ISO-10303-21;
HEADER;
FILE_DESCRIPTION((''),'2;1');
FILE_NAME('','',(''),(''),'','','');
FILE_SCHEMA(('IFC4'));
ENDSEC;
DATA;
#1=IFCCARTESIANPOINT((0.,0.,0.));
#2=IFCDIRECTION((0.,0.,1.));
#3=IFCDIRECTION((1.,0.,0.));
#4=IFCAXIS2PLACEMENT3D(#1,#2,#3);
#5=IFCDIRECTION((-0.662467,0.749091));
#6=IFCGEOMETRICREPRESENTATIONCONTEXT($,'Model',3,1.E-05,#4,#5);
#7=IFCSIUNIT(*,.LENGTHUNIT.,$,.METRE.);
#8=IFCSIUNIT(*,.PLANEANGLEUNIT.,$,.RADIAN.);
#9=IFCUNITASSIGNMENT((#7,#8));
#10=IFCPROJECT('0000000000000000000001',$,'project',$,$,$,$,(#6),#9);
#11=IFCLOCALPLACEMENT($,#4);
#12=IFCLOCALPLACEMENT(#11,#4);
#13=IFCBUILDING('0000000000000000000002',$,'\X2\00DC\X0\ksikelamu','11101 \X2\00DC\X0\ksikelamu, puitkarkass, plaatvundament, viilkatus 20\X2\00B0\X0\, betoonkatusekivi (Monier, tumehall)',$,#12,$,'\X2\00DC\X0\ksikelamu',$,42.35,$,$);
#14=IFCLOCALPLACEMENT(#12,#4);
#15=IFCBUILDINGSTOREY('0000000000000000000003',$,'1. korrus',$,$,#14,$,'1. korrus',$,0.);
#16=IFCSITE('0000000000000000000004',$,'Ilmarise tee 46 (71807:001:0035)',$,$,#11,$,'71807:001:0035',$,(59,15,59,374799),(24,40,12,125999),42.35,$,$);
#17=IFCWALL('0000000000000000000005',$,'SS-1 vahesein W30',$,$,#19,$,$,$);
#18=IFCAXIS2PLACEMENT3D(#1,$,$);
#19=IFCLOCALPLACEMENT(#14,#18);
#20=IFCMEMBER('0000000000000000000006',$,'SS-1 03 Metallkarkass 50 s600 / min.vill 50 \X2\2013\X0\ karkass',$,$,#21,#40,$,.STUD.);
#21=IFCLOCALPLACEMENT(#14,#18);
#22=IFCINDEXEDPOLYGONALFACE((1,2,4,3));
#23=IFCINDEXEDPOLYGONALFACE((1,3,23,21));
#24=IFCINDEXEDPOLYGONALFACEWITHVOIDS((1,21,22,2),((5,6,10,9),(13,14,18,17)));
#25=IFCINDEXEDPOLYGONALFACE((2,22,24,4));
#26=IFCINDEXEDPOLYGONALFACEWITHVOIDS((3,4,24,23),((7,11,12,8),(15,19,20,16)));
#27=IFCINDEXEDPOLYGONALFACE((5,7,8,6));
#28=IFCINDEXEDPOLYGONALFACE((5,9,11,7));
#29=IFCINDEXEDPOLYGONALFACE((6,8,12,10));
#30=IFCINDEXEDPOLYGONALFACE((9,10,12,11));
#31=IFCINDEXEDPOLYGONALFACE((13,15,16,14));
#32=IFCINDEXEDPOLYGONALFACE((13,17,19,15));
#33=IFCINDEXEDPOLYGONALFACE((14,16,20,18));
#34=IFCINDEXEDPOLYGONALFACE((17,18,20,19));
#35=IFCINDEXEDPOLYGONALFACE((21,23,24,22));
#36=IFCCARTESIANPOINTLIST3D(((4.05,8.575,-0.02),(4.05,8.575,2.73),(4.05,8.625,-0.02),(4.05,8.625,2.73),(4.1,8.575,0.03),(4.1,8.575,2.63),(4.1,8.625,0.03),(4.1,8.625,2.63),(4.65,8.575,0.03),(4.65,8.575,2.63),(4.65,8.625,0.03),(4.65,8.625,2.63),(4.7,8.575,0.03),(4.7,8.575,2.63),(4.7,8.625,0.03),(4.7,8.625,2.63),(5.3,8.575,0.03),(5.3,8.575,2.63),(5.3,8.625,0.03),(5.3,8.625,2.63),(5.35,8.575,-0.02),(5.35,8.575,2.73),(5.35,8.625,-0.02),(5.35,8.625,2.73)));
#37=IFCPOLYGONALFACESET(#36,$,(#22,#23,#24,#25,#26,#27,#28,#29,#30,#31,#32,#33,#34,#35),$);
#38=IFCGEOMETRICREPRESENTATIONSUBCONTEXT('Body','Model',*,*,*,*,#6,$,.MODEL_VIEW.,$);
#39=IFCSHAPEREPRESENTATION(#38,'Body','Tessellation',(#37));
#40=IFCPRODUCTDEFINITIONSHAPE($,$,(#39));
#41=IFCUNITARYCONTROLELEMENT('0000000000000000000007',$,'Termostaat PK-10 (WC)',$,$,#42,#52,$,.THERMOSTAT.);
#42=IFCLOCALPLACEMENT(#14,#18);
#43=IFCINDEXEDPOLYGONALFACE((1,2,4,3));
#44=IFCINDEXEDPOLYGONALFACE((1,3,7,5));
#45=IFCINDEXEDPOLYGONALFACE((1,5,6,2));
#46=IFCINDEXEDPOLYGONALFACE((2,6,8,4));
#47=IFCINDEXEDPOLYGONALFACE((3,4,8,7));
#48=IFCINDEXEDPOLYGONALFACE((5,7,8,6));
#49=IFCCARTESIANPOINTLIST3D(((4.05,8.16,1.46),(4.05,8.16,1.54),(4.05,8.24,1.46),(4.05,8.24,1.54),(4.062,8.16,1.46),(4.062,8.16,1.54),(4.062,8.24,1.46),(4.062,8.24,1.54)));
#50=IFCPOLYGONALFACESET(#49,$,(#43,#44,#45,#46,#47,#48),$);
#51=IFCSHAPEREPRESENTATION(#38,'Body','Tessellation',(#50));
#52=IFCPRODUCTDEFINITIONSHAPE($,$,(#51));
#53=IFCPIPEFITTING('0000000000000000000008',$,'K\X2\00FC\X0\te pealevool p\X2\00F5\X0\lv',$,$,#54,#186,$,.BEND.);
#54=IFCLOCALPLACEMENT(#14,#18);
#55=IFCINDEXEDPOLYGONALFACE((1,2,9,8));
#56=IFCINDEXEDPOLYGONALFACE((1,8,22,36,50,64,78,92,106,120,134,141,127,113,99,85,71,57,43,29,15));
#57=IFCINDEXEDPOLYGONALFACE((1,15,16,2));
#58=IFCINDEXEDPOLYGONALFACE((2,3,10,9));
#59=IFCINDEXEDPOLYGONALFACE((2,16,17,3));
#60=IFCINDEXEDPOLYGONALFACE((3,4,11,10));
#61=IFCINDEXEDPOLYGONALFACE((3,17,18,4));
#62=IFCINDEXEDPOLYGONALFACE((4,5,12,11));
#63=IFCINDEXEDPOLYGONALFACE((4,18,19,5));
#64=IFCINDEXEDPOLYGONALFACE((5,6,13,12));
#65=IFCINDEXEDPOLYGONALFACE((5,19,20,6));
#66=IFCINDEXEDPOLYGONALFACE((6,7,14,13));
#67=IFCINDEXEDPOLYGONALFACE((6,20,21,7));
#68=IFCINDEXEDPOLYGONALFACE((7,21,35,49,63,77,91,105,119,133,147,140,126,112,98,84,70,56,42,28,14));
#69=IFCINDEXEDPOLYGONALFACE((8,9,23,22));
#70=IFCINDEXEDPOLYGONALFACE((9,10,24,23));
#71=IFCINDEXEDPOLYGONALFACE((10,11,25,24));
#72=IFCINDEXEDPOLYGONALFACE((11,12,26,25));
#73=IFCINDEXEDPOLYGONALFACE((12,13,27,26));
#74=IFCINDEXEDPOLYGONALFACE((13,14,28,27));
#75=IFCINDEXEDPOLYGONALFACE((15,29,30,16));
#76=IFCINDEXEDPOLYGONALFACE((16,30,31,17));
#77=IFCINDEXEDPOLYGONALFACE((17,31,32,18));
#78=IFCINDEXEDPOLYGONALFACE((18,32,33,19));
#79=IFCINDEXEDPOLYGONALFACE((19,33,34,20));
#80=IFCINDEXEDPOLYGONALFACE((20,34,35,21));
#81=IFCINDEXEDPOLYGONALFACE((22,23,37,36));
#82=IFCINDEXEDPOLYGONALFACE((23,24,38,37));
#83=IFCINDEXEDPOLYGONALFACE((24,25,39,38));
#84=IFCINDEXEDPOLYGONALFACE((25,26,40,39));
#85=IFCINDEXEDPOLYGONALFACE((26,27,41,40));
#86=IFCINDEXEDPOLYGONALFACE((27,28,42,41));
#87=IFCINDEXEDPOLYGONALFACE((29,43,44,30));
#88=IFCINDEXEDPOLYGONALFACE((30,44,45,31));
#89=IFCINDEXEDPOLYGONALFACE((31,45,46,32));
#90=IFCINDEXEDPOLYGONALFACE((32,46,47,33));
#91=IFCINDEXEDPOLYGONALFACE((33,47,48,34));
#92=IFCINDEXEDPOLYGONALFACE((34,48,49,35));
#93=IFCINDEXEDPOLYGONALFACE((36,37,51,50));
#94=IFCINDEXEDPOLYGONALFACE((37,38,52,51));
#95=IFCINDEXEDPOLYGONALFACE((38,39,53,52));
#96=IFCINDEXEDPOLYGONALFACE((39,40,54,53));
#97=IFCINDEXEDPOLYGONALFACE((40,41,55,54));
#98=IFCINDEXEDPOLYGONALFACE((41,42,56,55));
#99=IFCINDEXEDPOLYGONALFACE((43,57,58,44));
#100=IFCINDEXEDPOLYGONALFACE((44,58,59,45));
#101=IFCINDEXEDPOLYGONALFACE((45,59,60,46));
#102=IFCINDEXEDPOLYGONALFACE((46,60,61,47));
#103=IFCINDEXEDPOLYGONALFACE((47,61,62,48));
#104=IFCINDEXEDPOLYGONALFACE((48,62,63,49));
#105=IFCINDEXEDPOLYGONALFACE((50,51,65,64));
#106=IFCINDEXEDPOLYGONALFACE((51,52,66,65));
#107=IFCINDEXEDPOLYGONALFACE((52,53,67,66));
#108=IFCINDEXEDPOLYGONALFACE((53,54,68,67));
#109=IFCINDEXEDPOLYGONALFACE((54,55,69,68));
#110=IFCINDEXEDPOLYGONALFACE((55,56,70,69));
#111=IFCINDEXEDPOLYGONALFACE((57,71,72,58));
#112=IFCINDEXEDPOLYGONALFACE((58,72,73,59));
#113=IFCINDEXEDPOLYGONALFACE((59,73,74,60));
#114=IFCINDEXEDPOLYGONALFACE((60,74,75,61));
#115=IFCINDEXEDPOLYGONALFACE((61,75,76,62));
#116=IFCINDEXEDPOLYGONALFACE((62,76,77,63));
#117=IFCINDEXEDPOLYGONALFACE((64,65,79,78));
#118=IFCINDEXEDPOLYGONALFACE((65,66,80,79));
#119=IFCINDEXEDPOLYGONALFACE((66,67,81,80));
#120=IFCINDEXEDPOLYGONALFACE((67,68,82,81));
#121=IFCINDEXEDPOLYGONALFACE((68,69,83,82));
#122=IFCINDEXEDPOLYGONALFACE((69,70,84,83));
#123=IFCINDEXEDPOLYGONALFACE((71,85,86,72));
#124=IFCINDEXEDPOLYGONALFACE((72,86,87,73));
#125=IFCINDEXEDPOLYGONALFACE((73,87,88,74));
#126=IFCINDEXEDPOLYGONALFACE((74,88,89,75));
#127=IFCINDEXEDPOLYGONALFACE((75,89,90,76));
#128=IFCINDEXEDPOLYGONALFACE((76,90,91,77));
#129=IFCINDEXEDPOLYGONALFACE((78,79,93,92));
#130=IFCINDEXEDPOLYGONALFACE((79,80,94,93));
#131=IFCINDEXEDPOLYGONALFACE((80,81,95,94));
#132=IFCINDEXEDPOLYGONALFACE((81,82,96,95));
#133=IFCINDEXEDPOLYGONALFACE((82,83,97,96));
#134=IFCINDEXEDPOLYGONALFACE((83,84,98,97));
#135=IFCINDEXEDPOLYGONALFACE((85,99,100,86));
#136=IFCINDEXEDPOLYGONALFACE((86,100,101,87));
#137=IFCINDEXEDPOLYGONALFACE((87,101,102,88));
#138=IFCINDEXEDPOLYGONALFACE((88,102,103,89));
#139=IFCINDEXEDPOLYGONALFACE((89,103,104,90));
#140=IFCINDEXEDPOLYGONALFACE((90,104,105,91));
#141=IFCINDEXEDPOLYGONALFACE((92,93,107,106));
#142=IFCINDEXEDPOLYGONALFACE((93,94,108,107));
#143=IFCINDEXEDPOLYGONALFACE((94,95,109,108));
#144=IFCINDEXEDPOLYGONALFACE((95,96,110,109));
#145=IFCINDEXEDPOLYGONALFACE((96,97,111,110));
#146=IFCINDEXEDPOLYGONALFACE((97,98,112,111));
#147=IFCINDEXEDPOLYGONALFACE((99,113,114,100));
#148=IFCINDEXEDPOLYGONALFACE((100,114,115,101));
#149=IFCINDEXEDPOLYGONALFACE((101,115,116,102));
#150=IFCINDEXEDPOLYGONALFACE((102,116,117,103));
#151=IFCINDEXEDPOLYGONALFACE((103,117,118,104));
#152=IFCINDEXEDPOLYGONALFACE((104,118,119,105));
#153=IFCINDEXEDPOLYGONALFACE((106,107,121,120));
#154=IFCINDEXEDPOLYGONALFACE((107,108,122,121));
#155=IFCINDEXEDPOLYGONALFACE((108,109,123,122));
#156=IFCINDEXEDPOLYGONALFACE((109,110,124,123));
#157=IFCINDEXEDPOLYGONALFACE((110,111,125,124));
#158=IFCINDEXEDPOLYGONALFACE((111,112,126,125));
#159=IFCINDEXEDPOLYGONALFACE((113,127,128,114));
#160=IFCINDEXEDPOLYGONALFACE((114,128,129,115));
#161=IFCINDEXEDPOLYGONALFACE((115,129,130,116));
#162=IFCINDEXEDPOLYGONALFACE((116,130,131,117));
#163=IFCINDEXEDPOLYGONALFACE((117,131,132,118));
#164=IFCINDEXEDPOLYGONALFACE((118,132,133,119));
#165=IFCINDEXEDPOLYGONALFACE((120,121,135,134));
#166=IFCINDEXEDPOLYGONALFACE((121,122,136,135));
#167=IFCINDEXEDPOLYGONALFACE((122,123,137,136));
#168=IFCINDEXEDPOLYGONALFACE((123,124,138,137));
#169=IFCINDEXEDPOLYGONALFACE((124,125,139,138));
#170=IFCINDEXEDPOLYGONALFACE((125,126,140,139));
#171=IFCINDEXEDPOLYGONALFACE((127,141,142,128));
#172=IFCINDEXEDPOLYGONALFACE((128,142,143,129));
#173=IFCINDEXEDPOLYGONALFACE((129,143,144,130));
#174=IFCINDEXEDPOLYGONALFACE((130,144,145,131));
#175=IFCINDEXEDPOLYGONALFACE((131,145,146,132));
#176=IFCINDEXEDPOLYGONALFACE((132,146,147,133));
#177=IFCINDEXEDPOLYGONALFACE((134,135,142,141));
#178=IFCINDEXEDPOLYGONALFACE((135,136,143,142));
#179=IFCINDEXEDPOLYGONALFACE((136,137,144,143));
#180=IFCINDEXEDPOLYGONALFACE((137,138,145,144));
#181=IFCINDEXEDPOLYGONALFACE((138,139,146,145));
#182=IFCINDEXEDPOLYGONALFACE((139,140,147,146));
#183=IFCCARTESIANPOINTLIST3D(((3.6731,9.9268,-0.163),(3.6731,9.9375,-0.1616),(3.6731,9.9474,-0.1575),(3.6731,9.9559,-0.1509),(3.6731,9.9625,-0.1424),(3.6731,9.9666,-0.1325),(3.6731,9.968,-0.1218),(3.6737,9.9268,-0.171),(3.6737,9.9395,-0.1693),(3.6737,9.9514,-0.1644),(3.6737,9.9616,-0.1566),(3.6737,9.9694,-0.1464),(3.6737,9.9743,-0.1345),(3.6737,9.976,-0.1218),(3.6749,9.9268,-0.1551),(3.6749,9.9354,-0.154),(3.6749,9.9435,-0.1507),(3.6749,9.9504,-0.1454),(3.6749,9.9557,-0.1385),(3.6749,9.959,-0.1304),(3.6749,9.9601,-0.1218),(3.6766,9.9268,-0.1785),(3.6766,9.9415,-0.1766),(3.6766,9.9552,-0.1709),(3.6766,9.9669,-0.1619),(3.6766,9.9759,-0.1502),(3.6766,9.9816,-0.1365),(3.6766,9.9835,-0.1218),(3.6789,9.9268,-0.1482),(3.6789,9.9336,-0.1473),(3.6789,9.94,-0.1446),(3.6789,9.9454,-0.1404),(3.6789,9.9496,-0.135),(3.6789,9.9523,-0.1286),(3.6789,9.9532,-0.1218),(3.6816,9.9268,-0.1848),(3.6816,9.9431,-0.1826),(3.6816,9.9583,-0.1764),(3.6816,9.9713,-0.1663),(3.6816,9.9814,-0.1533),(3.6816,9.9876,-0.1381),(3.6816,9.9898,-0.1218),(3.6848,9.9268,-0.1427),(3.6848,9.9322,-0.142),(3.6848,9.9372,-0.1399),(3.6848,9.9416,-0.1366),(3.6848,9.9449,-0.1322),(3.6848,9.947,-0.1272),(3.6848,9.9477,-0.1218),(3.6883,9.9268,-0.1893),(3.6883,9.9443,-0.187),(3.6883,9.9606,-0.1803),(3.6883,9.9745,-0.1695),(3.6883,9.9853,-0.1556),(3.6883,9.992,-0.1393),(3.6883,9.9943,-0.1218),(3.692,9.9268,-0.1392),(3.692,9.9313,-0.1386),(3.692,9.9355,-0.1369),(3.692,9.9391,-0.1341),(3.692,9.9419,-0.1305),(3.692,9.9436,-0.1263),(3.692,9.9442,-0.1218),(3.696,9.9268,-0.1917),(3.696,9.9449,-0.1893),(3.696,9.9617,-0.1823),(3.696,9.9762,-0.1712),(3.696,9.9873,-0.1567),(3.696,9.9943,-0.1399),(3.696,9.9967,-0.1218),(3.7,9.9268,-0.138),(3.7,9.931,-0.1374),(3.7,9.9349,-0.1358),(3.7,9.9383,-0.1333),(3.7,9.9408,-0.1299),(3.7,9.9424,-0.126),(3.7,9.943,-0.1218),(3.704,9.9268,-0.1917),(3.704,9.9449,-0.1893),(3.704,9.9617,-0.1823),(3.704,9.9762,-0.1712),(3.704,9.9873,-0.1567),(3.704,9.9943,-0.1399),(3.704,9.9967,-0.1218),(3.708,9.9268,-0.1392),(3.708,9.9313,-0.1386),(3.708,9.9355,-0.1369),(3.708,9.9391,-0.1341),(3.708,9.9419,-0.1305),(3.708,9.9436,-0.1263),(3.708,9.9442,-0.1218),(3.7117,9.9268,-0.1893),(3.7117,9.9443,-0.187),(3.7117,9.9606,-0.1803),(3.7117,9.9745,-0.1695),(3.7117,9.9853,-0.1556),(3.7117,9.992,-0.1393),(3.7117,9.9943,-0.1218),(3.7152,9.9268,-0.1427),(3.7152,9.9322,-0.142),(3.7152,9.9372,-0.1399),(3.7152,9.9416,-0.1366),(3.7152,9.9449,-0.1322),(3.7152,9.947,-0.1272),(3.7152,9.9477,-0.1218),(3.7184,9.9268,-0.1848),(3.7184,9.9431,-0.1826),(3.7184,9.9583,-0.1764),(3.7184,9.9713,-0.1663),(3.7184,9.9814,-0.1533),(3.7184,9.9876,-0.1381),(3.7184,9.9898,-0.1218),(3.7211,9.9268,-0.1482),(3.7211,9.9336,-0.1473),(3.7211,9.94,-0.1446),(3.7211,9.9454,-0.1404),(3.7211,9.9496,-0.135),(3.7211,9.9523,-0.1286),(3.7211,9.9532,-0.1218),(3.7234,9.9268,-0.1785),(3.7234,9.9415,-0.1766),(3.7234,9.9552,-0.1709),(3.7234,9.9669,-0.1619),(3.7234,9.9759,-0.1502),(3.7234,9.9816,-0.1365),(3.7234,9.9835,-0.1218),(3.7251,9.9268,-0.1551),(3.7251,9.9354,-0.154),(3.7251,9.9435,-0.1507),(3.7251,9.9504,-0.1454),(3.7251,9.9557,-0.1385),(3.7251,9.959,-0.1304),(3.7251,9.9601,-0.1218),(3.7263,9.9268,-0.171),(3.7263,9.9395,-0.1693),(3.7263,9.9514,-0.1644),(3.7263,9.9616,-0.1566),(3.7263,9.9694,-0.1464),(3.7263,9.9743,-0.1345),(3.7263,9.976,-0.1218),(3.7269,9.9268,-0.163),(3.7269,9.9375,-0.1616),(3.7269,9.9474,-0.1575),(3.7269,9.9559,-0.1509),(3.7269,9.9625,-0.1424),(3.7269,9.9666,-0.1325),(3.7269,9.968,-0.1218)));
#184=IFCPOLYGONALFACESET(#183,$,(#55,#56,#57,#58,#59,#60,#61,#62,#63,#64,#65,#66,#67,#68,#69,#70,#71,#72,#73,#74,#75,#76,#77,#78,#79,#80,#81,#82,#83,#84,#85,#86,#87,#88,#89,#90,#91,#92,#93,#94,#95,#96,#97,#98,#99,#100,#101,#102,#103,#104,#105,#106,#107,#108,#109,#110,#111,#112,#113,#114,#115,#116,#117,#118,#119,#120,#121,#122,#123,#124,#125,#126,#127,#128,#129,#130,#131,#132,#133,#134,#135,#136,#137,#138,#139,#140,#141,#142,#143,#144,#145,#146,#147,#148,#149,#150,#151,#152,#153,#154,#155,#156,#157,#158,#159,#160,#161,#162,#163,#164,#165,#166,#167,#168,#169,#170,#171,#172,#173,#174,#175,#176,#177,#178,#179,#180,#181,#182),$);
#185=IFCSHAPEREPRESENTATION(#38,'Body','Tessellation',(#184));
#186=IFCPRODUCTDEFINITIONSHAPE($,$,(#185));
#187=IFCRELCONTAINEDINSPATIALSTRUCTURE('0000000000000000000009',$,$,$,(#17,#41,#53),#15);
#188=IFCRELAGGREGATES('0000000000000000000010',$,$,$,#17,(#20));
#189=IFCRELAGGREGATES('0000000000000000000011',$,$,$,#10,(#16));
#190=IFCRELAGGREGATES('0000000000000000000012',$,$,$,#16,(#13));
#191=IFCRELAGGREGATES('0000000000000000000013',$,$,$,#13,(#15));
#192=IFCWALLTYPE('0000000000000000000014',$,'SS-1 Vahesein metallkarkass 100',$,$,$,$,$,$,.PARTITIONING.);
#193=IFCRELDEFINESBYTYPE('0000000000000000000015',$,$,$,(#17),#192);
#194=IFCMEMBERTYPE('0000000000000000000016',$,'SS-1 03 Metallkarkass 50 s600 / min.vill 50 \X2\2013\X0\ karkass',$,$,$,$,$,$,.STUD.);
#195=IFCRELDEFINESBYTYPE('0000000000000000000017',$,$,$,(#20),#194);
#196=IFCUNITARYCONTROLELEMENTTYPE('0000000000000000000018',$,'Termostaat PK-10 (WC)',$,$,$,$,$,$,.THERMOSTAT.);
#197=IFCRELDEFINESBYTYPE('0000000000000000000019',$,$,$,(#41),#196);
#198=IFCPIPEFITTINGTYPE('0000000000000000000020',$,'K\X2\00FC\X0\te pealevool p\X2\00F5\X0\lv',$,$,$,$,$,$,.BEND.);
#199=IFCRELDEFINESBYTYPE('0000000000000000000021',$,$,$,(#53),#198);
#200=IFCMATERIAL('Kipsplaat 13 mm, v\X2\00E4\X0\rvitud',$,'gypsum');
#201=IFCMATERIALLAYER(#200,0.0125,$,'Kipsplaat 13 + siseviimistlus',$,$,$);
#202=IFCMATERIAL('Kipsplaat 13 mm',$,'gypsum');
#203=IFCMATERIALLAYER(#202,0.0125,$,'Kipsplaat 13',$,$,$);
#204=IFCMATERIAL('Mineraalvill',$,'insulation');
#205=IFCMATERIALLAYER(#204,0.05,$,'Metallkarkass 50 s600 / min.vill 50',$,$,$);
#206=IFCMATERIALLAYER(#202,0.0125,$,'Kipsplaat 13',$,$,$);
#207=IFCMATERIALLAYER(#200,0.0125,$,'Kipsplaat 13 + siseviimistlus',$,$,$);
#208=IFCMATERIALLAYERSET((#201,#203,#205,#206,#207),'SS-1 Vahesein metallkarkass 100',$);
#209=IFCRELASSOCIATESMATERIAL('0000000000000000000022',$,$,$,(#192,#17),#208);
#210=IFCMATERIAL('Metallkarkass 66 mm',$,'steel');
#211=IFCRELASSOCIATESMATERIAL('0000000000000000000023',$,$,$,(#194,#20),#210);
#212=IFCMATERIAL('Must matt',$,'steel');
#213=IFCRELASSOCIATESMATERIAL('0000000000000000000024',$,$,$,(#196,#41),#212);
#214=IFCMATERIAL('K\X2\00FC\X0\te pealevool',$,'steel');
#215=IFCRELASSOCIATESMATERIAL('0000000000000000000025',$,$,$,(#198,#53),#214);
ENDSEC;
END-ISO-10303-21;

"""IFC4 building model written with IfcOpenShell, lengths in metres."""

from ifc_helpers import new_model, entity, si_unit, direction, frame, origin_with_axes, place, context, subcontext, project, spatial, indexed_curve, outline, extrude, material, layer, layer_set, layer_usage, type_object, element, aggregate, save


model = new_model("IFC4")

# Units and contexts
model_context = context("Model", 3, precision=1e-05, world=origin_with_axes(), true_north=direction((-0.662467, 0.749091)))
body_context = subcontext(model_context, "Body", "Model", "MODEL_VIEW")
ifc_project = project(units=[si_unit("LENGTHUNIT", "METRE"), si_unit("PLANEANGLEUNIT", "RADIAN")], contexts=[model_context])

# Site, building, storey
site_placement = place(None, origin_with_axes())
site = spatial("IfcSite", under=ifc_project, at=site_placement, Name="Ilmarise tee 46 (71807:001:0035)", LongName="71807:001:0035", RefLatitude=(59, 15, 59, 374799), RefLongitude=(24, 40, 12, 125999), RefElevation=42.35)
building_placement = place(site_placement, origin_with_axes())
building = spatial("IfcBuilding", under=site, at=building_placement, Name="Üksikelamu", Description="11101 Üksikelamu, puitkarkass, plaatvundament, viilkatus 20°, betoonkatusekivi (Monier, tumehall)", LongName="Üksikelamu", ElevationOfRefHeight=42.35)
storey_placement = place(building_placement, origin_with_axes())
storey = spatial("IfcBuildingStorey", under=building, at=storey_placement, Name="1. korrus", LongName="1. korrus", Elevation=0.0)

# Wall, member
ifc_material_1 = material(Name="Kipsplaat 13 mm, värvitud", Category="gypsum")
ifc_layer_1 = layer(ifc_material_1, 0.0125, Name="Kipsplaat 13 + siseviimistlus")
ifc_material_2 = material(Name="Kipsplaat 13 mm", Category="gypsum")
ifc_layer_2 = layer(ifc_material_2, 0.0125, Name="Kipsplaat 13")
ifc_material_3 = material(Name="Mineraalvill", Category="insulation")
ifc_layer_3 = layer(ifc_material_3, 0.05, Name="Metallkarkass 50 s600 / min.vill 50")
ifc_layer_4 = layer(ifc_material_2, 0.0125, Name="Kipsplaat 13")
ifc_layer_5 = layer(ifc_material_1, 0.0125, Name="Kipsplaat 13 + siseviimistlus")
ifc_layer_set = layer_set([ifc_layer_1, ifc_layer_2, ifc_layer_3, ifc_layer_4, ifc_layer_5], Name="SS-1 Vahesein metallkarkass 100")
ifc_layer_usage = layer_usage(ifc_layer_set, "AXIS2", "POSITIVE", 0.0)
wall_type = type_object("IfcWallType", Name="SS-1 Vahesein metallkarkass 100", PredefinedType="PARTITIONING", material=ifc_layer_set)
wall_placement = place(storey_placement, frame((4.05, 8.55, 0.0), z_axis=(0.0, 0.0, 1.0), x_axis=(1.0, 0.0, 0.0)))
wall = element("IfcWall", 1, at=wall_placement, inside=storey, type_object=wall_type, material=ifc_layer_usage, Name="SS-1 vahesein W30")
ifc_material_4 = material(Name="Metallkarkass 66 mm", Category="steel")
member_type = type_object("IfcMemberType", Name="SS-1 03 Metallkarkass 50 s600 / min.vill 50 – karkass", PredefinedType="STUD", material=ifc_material_4)
member_placement = place(wall_placement, origin_with_axes())
member = element("IfcMember", 2, at=member_placement, type_object=member_type, material=ifc_material_4, Name="SS-1 03 Metallkarkass 50 s600 / min.vill 50 – karkass", PredefinedType="STUD", context=body_context, shape_type="SweptSolid", body=[
    extrude(outline(indexed_curve([(1.3, -0.02), (0.0, -0.02), (0.0, 2.73), (1.3, 2.73), (1.3, -0.02)], self_intersect=False), holes=[indexed_curve([(0.6, 0.03), (0.6, 2.63), (0.05, 2.63), (0.05, 0.03), (0.6, 0.03)], self_intersect=False), indexed_curve([(1.25, 2.63), (0.65, 2.63), (0.65, 0.03), (1.25, 0.03), (1.25, 2.63)], self_intersect=False)]), frame((0.0, 0.075, 0.0), z_axis=(0.0, -1.0, 0.0), x_axis=(1.0, 0.0, 0.0)), (0.0, 0.0, 1.0), 0.05),
])

# Unitary control element
ifc_material_5 = material(Name="Must matt", Category="steel")
unitary_control_element_type = type_object("IfcUnitaryControlElementType", Name="Termostaat PK-10 (WC)", PredefinedType="THERMOSTAT", material=ifc_material_5)
unitary_control_element_placement = place(storey_placement, frame((4.062, 8.2, 0.0), z_axis=(0.0, 0.0, 1.0), x_axis=(0.0, -1.0, 0.0)))
element("IfcUnitaryControlElement", 3, at=unitary_control_element_placement, inside=storey, type_object=unitary_control_element_type, material=ifc_material_5, Name="Termostaat PK-10 (WC)", PredefinedType="THERMOSTAT", context=body_context, shape_type="SweptSolid", body=[
    extrude(outline(indexed_curve([(-0.04, -0.012), (0.04, -0.012), (0.04, 0.0), (-0.04, 0.0), (-0.04, -0.012)], self_intersect=False)), frame((0.0, 0.0, 1.46), z_axis=(0.0, 0.0, 1.0), x_axis=(1.0, 0.0, 0.0)), (0.0, 0.0, 1.0), 0.08),
])

# Pipe fitting
ifc_material_6 = material(Name="Küte pealevool", Category="steel")
pipe_fitting_type_1 = type_object("IfcPipeFittingType", Name="Küte pealevool põlv", PredefinedType="BEND", material=ifc_material_6)
pipe_fitting_1_placement = place(storey_placement, frame((3.7, 9.97, -0.165), z_axis=(0.0, 0.0, 1.0), x_axis=(1.0, 0.0, 0.0)))
element("IfcPipeFitting", 4, at=pipe_fitting_1_placement, inside=storey, type_object=pipe_fitting_type_1, material=ifc_material_6, Name="Küte pealevool põlv", PredefinedType="BEND", context=body_context, shape_type="SweptSolid", body=[
    entity("IfcRevolvedAreaSolid", entity("IfcCircleProfileDef", "AREA", None, None, 0.027), entity("IfcAxis2Placement3D", entity("IfcCartesianPoint", [0.0, 0.0, 0.0432]), entity("IfcDirection", [0.0, 0.0, -1.0]), entity("IfcDirection", [0.0, -1.0, 0.0])), entity("IfcAxis1Placement", entity("IfcCartesianPoint", [0.0432, 0.0, 0.0]), entity("IfcDirection", [0.0, 1.0, 0.0])), 1.570796),
])

aggregate(wall, [member])

save(model, "model.ifc")
